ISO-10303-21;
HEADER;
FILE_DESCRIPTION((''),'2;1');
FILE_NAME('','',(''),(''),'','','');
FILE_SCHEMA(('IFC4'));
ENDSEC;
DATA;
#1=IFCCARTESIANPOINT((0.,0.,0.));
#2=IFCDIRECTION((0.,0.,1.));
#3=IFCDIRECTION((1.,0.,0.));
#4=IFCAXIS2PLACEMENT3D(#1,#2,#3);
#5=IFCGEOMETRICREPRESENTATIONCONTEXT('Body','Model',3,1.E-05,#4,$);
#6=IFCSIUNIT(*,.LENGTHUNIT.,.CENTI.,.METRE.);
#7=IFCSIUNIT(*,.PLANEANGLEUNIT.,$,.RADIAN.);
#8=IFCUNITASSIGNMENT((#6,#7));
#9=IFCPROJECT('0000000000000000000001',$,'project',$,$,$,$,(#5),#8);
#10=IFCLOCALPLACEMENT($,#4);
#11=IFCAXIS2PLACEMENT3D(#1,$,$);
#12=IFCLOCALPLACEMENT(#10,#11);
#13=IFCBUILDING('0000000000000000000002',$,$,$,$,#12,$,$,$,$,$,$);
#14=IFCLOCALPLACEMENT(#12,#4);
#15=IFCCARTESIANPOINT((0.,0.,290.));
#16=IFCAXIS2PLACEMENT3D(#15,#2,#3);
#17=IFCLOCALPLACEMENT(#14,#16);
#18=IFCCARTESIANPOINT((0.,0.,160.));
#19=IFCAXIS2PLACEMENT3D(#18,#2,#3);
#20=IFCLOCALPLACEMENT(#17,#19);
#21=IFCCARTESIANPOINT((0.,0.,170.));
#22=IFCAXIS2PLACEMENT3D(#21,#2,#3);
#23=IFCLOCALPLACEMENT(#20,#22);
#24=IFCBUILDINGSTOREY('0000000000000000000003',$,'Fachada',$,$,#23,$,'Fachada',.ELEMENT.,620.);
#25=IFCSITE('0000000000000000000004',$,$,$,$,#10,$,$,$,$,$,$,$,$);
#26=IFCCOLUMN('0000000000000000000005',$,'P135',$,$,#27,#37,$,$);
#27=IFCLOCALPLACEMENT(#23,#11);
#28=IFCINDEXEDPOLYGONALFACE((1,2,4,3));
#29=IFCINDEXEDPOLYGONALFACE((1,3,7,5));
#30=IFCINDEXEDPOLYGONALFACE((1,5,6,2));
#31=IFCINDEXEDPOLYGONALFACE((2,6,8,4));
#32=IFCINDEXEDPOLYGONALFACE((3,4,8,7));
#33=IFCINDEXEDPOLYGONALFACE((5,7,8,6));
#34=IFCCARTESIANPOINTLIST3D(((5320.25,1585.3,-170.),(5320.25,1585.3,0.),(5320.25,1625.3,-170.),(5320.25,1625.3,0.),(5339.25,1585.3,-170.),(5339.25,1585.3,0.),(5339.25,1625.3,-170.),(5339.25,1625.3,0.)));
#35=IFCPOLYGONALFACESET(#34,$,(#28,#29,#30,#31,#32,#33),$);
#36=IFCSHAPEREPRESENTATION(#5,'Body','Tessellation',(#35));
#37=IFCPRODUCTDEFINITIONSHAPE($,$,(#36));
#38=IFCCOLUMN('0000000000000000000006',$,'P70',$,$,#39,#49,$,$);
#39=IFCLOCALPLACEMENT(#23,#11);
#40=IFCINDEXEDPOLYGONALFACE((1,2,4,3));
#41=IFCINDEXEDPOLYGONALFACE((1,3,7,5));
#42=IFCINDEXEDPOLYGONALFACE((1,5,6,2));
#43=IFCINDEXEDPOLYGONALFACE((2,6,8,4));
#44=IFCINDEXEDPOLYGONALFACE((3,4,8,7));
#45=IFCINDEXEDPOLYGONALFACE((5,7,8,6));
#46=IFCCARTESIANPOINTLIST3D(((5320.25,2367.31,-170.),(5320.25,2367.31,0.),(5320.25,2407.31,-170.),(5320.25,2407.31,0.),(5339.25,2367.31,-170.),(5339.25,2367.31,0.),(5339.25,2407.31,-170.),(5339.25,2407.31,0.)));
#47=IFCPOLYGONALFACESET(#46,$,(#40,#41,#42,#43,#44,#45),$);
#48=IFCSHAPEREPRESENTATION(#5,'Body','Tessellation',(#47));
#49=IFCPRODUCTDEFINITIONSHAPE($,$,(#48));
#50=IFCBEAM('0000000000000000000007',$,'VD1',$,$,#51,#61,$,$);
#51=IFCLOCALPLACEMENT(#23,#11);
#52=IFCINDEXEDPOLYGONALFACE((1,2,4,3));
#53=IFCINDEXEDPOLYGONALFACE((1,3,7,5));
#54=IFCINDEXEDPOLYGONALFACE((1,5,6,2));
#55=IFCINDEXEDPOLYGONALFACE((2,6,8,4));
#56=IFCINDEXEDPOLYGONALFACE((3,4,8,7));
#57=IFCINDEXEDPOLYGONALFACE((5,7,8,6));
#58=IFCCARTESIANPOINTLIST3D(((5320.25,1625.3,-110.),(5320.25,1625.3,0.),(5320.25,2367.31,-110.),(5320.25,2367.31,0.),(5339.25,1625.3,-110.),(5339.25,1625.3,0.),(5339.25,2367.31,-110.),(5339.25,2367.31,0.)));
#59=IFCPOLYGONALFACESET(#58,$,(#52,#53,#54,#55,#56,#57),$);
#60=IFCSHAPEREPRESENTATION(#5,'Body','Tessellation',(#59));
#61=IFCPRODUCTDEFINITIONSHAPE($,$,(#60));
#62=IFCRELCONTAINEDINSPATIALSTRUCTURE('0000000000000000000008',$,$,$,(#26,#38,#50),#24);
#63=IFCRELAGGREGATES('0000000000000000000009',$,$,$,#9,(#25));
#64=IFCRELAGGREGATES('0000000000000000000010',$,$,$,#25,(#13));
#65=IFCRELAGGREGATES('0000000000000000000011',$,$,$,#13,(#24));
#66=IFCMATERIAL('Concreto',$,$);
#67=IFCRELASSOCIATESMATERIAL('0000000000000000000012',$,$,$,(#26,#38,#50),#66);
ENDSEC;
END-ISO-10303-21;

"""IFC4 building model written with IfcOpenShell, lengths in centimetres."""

from ifc_helpers import new_model, si_unit, frame, origin, origin_with_axes, origin_2d_with_axis, place, context, project, spatial, rectangle, extrude, material, element, save


model = new_model("IFC4")

# Units and contexts
model_context = context("Model", 3, precision=1e-05, world=origin_with_axes(), identifier="Body")
ifc_project = project(units=[si_unit("LENGTHUNIT", "METRE", prefix="CENTI"), si_unit("PLANEANGLEUNIT", "RADIAN")], contexts=[model_context])

# Site, building, storey
site_placement = place(None, origin_with_axes())
site = spatial("IfcSite", under=ifc_project, at=site_placement)
building_placement = place(site_placement, origin())
building = spatial("IfcBuilding", under=site, at=building_placement)
placement_1 = place(building_placement, origin_with_axes())
placement_2 = place(placement_1, frame((0.0, 0.0, 290.0), z_axis=(0.0, 0.0, 1.0), x_axis=(1.0, 0.0, 0.0)))
placement_3 = place(placement_2, frame((0.0, 0.0, 160.0), z_axis=(0.0, 0.0, 1.0), x_axis=(1.0, 0.0, 0.0)))
storey_placement = place(placement_3, frame((0.0, 0.0, 170.0), z_axis=(0.0, 0.0, 1.0), x_axis=(1.0, 0.0, 0.0)))
storey = spatial("IfcBuildingStorey", under=building, at=storey_placement, Name="Fachada", LongName="Fachada", CompositionType="ELEMENT", Elevation=620.0)

# Columns
ifc_material = material(Name="Concreto")
for number, where, z_axis, x_axis, name in (
    (1, (5329.75, 1605.3, 0.0), (0.0, 0.0, 1.0), (1.0, 0.0, 0.0), "P135"),
    (2, (5329.75, 2387.31, 0.0), (0.0, 0.0, 1.0), (1.0, 0.0, 0.0), "P70"),
):
    element("IfcColumn", number, at=place(storey_placement, frame(where, z_axis=z_axis, x_axis=x_axis)), inside=storey, material=ifc_material, Name=name, context=model_context, shape_type="SolidModel", body=[
        extrude(rectangle(XDim=19.0, YDim=40.0, at=origin_2d_with_axis()), origin_with_axes(), (0.0, 0.0, -1.0), 170.0),
    ])

# Beam
beam_placement = place(storey_placement, frame((5329.75, 1996.31, 0.0), z_axis=(0.0, 0.0, 1.0), x_axis=(1.0, 0.0, 0.0)))
element("IfcBeam", 3, at=beam_placement, inside=storey, material=ifc_material, Name="VD1", context=model_context, shape_type="SolidModel", body=[
    extrude(rectangle(XDim=19.0, YDim=110.0, at=origin_2d_with_axis()), frame((0.0, -371.0, -55.0), z_axis=(0.0, 1.0, 0.0), x_axis=(1.0, 0.0, 0.0)), (0.0, 0.0, 1.0), 742.01),
])

save(model, "model.ifc")
